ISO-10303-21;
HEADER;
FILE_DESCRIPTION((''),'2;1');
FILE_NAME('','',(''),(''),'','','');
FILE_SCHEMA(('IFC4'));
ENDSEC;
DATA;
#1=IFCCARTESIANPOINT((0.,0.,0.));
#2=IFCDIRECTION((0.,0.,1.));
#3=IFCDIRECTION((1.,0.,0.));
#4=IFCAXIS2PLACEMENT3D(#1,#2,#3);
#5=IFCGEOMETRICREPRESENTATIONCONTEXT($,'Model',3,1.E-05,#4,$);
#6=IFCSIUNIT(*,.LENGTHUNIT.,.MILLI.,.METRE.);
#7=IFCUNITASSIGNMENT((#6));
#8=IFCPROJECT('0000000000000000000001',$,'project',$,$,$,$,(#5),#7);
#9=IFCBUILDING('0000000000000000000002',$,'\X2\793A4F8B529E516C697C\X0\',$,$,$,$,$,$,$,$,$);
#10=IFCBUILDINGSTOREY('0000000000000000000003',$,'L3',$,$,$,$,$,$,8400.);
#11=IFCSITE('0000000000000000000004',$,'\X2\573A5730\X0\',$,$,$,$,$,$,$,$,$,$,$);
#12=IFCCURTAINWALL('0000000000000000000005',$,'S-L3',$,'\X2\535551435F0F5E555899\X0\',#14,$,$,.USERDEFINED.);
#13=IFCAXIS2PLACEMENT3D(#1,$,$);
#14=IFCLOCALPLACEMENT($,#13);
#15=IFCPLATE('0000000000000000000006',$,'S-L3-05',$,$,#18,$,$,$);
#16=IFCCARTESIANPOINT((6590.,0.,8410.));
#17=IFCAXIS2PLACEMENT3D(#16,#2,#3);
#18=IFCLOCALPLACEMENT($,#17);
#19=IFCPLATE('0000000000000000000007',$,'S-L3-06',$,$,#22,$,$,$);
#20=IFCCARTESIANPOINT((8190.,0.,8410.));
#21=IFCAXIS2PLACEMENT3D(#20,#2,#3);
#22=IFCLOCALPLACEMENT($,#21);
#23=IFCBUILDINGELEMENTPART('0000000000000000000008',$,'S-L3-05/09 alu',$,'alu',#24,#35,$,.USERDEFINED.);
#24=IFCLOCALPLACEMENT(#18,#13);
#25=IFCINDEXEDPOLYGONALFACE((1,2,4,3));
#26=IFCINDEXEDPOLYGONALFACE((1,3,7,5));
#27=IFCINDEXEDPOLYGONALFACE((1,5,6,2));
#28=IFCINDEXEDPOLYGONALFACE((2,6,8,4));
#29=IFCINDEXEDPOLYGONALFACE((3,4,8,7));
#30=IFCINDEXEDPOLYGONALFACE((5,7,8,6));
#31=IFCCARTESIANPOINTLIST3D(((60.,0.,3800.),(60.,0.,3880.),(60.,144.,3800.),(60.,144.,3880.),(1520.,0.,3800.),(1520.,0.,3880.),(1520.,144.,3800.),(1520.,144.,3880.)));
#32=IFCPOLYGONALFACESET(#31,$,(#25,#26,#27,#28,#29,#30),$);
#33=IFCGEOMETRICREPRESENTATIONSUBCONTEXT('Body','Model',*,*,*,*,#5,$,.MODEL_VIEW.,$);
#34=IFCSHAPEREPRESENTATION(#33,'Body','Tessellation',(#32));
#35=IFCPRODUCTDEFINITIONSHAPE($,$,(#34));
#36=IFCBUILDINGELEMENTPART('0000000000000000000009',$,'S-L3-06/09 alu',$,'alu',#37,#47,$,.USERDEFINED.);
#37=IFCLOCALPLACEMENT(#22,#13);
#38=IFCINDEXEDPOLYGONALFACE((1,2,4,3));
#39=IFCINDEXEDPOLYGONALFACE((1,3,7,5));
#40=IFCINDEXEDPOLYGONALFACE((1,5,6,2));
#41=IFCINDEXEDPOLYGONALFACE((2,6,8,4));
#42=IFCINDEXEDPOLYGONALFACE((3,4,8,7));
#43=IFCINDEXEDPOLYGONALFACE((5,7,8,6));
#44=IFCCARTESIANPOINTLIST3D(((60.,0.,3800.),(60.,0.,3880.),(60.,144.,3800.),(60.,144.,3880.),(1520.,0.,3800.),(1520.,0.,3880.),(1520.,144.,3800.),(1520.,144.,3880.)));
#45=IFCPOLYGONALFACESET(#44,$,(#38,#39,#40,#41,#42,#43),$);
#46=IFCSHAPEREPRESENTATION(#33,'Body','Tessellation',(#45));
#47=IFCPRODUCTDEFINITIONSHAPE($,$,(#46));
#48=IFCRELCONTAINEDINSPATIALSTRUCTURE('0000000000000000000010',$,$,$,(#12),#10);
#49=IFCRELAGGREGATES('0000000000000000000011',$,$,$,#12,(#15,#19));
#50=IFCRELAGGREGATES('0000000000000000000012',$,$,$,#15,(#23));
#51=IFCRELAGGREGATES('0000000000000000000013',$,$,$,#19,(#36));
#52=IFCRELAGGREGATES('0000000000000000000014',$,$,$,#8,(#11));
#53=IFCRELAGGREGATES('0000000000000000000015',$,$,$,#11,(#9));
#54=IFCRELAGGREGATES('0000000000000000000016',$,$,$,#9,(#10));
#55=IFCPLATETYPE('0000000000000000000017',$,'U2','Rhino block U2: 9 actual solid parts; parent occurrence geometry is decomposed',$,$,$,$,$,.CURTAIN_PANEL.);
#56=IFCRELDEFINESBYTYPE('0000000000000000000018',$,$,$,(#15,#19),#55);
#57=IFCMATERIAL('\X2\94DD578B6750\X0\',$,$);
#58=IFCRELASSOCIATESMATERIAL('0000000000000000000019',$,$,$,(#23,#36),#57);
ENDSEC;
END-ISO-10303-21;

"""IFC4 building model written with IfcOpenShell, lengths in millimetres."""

from ifc_helpers import new_model, si_unit, frame, frame_2d, origin, origin_with_axes, place, context, subcontext, project, spatial, rectangle, extrude, source, transform, mapped, material, type_object, element, aggregate, save


model = new_model("IFC4")

# Units and contexts
model_context = context("Model", 3, precision=1e-05, world=origin_with_axes())
body_context = subcontext(model_context, "Body", "Model", "MODEL_VIEW")
ifc_project = project(units=[si_unit("LENGTHUNIT", "METRE", prefix="MILLI")], contexts=[model_context])

# Site, building, storey
site = spatial("IfcSite", under=ifc_project, Name="场地")
building = spatial("IfcBuilding", under=site, Name="示例办公楼")
storey = spatial("IfcBuildingStorey", under=building, Name="L3", Elevation=8400.0)

# Curtain wall, plates, building element parts
curtain_wall = element("IfcCurtainWall", 1, inside=storey, Name="S-L3", ObjectType="单元式幕墙", PredefinedType="USERDEFINED")
plate_type = type_object("IfcPlateType", Name="U2", Description="Rhino block U2: 9 actual solid parts; parent occurrence geometry is decomposed", PredefinedType="CURTAIN_PANEL")
plate_1_placement = place(None, frame((6590.0, 0.0, 8410.0), z_axis=(0.0, 0.0, 1.0), x_axis=(1.0, 0.0, 0.0)))
plate_1 = element("IfcPlate", 2, at=plate_1_placement, type_object=plate_type, Name="S-L3-05")
ifc_material_1 = material(Name="铝型材")
plate_2_placement = place(None, frame((8190.0, 0.0, 8410.0), z_axis=(0.0, 0.0, 1.0), x_axis=(1.0, 0.0, 0.0)))
plate_2 = element("IfcPlate", 3, at=plate_2_placement, type_object=plate_type, Name="S-L3-06")
aggregate(curtain_wall, [plate_1, plate_2])
shared_shape_1 = source(origin(), body_context, "Body", "SweptSolid", [
    extrude(rectangle(XDim=1460.0, YDim=144.0, at=frame_2d((790.0, 72.0))), frame((0.0, 0.0, 3800.0)), (0.0, 0.0, 1.0), 80.0),
])
building_element_part_1_placement = place(plate_1_placement, origin())
building_element_part_1 = element("IfcBuildingElementPart", 4, at=building_element_part_1_placement, material=ifc_material_1, Name="S-L3-05/09 alu", ObjectType="alu", PredefinedType="USERDEFINED", context=body_context, shape_type="MappedRepresentation", body=[
    mapped(shared_shape_1, transform((0.0, 0.0, 0.0))),
])
aggregate(plate_1, [building_element_part_1])
building_element_part_2_placement = place(plate_2_placement, origin())
building_element_part_2 = element("IfcBuildingElementPart", 5, at=building_element_part_2_placement, material=ifc_material_1, Name="S-L3-06/09 alu", ObjectType="alu", PredefinedType="USERDEFINED", context=body_context, shape_type="MappedRepresentation", body=[
    mapped(shared_shape_1, transform((0.0, 0.0, 0.0))),
])
aggregate(plate_2, [building_element_part_2])

save(model, "model.ifc")
